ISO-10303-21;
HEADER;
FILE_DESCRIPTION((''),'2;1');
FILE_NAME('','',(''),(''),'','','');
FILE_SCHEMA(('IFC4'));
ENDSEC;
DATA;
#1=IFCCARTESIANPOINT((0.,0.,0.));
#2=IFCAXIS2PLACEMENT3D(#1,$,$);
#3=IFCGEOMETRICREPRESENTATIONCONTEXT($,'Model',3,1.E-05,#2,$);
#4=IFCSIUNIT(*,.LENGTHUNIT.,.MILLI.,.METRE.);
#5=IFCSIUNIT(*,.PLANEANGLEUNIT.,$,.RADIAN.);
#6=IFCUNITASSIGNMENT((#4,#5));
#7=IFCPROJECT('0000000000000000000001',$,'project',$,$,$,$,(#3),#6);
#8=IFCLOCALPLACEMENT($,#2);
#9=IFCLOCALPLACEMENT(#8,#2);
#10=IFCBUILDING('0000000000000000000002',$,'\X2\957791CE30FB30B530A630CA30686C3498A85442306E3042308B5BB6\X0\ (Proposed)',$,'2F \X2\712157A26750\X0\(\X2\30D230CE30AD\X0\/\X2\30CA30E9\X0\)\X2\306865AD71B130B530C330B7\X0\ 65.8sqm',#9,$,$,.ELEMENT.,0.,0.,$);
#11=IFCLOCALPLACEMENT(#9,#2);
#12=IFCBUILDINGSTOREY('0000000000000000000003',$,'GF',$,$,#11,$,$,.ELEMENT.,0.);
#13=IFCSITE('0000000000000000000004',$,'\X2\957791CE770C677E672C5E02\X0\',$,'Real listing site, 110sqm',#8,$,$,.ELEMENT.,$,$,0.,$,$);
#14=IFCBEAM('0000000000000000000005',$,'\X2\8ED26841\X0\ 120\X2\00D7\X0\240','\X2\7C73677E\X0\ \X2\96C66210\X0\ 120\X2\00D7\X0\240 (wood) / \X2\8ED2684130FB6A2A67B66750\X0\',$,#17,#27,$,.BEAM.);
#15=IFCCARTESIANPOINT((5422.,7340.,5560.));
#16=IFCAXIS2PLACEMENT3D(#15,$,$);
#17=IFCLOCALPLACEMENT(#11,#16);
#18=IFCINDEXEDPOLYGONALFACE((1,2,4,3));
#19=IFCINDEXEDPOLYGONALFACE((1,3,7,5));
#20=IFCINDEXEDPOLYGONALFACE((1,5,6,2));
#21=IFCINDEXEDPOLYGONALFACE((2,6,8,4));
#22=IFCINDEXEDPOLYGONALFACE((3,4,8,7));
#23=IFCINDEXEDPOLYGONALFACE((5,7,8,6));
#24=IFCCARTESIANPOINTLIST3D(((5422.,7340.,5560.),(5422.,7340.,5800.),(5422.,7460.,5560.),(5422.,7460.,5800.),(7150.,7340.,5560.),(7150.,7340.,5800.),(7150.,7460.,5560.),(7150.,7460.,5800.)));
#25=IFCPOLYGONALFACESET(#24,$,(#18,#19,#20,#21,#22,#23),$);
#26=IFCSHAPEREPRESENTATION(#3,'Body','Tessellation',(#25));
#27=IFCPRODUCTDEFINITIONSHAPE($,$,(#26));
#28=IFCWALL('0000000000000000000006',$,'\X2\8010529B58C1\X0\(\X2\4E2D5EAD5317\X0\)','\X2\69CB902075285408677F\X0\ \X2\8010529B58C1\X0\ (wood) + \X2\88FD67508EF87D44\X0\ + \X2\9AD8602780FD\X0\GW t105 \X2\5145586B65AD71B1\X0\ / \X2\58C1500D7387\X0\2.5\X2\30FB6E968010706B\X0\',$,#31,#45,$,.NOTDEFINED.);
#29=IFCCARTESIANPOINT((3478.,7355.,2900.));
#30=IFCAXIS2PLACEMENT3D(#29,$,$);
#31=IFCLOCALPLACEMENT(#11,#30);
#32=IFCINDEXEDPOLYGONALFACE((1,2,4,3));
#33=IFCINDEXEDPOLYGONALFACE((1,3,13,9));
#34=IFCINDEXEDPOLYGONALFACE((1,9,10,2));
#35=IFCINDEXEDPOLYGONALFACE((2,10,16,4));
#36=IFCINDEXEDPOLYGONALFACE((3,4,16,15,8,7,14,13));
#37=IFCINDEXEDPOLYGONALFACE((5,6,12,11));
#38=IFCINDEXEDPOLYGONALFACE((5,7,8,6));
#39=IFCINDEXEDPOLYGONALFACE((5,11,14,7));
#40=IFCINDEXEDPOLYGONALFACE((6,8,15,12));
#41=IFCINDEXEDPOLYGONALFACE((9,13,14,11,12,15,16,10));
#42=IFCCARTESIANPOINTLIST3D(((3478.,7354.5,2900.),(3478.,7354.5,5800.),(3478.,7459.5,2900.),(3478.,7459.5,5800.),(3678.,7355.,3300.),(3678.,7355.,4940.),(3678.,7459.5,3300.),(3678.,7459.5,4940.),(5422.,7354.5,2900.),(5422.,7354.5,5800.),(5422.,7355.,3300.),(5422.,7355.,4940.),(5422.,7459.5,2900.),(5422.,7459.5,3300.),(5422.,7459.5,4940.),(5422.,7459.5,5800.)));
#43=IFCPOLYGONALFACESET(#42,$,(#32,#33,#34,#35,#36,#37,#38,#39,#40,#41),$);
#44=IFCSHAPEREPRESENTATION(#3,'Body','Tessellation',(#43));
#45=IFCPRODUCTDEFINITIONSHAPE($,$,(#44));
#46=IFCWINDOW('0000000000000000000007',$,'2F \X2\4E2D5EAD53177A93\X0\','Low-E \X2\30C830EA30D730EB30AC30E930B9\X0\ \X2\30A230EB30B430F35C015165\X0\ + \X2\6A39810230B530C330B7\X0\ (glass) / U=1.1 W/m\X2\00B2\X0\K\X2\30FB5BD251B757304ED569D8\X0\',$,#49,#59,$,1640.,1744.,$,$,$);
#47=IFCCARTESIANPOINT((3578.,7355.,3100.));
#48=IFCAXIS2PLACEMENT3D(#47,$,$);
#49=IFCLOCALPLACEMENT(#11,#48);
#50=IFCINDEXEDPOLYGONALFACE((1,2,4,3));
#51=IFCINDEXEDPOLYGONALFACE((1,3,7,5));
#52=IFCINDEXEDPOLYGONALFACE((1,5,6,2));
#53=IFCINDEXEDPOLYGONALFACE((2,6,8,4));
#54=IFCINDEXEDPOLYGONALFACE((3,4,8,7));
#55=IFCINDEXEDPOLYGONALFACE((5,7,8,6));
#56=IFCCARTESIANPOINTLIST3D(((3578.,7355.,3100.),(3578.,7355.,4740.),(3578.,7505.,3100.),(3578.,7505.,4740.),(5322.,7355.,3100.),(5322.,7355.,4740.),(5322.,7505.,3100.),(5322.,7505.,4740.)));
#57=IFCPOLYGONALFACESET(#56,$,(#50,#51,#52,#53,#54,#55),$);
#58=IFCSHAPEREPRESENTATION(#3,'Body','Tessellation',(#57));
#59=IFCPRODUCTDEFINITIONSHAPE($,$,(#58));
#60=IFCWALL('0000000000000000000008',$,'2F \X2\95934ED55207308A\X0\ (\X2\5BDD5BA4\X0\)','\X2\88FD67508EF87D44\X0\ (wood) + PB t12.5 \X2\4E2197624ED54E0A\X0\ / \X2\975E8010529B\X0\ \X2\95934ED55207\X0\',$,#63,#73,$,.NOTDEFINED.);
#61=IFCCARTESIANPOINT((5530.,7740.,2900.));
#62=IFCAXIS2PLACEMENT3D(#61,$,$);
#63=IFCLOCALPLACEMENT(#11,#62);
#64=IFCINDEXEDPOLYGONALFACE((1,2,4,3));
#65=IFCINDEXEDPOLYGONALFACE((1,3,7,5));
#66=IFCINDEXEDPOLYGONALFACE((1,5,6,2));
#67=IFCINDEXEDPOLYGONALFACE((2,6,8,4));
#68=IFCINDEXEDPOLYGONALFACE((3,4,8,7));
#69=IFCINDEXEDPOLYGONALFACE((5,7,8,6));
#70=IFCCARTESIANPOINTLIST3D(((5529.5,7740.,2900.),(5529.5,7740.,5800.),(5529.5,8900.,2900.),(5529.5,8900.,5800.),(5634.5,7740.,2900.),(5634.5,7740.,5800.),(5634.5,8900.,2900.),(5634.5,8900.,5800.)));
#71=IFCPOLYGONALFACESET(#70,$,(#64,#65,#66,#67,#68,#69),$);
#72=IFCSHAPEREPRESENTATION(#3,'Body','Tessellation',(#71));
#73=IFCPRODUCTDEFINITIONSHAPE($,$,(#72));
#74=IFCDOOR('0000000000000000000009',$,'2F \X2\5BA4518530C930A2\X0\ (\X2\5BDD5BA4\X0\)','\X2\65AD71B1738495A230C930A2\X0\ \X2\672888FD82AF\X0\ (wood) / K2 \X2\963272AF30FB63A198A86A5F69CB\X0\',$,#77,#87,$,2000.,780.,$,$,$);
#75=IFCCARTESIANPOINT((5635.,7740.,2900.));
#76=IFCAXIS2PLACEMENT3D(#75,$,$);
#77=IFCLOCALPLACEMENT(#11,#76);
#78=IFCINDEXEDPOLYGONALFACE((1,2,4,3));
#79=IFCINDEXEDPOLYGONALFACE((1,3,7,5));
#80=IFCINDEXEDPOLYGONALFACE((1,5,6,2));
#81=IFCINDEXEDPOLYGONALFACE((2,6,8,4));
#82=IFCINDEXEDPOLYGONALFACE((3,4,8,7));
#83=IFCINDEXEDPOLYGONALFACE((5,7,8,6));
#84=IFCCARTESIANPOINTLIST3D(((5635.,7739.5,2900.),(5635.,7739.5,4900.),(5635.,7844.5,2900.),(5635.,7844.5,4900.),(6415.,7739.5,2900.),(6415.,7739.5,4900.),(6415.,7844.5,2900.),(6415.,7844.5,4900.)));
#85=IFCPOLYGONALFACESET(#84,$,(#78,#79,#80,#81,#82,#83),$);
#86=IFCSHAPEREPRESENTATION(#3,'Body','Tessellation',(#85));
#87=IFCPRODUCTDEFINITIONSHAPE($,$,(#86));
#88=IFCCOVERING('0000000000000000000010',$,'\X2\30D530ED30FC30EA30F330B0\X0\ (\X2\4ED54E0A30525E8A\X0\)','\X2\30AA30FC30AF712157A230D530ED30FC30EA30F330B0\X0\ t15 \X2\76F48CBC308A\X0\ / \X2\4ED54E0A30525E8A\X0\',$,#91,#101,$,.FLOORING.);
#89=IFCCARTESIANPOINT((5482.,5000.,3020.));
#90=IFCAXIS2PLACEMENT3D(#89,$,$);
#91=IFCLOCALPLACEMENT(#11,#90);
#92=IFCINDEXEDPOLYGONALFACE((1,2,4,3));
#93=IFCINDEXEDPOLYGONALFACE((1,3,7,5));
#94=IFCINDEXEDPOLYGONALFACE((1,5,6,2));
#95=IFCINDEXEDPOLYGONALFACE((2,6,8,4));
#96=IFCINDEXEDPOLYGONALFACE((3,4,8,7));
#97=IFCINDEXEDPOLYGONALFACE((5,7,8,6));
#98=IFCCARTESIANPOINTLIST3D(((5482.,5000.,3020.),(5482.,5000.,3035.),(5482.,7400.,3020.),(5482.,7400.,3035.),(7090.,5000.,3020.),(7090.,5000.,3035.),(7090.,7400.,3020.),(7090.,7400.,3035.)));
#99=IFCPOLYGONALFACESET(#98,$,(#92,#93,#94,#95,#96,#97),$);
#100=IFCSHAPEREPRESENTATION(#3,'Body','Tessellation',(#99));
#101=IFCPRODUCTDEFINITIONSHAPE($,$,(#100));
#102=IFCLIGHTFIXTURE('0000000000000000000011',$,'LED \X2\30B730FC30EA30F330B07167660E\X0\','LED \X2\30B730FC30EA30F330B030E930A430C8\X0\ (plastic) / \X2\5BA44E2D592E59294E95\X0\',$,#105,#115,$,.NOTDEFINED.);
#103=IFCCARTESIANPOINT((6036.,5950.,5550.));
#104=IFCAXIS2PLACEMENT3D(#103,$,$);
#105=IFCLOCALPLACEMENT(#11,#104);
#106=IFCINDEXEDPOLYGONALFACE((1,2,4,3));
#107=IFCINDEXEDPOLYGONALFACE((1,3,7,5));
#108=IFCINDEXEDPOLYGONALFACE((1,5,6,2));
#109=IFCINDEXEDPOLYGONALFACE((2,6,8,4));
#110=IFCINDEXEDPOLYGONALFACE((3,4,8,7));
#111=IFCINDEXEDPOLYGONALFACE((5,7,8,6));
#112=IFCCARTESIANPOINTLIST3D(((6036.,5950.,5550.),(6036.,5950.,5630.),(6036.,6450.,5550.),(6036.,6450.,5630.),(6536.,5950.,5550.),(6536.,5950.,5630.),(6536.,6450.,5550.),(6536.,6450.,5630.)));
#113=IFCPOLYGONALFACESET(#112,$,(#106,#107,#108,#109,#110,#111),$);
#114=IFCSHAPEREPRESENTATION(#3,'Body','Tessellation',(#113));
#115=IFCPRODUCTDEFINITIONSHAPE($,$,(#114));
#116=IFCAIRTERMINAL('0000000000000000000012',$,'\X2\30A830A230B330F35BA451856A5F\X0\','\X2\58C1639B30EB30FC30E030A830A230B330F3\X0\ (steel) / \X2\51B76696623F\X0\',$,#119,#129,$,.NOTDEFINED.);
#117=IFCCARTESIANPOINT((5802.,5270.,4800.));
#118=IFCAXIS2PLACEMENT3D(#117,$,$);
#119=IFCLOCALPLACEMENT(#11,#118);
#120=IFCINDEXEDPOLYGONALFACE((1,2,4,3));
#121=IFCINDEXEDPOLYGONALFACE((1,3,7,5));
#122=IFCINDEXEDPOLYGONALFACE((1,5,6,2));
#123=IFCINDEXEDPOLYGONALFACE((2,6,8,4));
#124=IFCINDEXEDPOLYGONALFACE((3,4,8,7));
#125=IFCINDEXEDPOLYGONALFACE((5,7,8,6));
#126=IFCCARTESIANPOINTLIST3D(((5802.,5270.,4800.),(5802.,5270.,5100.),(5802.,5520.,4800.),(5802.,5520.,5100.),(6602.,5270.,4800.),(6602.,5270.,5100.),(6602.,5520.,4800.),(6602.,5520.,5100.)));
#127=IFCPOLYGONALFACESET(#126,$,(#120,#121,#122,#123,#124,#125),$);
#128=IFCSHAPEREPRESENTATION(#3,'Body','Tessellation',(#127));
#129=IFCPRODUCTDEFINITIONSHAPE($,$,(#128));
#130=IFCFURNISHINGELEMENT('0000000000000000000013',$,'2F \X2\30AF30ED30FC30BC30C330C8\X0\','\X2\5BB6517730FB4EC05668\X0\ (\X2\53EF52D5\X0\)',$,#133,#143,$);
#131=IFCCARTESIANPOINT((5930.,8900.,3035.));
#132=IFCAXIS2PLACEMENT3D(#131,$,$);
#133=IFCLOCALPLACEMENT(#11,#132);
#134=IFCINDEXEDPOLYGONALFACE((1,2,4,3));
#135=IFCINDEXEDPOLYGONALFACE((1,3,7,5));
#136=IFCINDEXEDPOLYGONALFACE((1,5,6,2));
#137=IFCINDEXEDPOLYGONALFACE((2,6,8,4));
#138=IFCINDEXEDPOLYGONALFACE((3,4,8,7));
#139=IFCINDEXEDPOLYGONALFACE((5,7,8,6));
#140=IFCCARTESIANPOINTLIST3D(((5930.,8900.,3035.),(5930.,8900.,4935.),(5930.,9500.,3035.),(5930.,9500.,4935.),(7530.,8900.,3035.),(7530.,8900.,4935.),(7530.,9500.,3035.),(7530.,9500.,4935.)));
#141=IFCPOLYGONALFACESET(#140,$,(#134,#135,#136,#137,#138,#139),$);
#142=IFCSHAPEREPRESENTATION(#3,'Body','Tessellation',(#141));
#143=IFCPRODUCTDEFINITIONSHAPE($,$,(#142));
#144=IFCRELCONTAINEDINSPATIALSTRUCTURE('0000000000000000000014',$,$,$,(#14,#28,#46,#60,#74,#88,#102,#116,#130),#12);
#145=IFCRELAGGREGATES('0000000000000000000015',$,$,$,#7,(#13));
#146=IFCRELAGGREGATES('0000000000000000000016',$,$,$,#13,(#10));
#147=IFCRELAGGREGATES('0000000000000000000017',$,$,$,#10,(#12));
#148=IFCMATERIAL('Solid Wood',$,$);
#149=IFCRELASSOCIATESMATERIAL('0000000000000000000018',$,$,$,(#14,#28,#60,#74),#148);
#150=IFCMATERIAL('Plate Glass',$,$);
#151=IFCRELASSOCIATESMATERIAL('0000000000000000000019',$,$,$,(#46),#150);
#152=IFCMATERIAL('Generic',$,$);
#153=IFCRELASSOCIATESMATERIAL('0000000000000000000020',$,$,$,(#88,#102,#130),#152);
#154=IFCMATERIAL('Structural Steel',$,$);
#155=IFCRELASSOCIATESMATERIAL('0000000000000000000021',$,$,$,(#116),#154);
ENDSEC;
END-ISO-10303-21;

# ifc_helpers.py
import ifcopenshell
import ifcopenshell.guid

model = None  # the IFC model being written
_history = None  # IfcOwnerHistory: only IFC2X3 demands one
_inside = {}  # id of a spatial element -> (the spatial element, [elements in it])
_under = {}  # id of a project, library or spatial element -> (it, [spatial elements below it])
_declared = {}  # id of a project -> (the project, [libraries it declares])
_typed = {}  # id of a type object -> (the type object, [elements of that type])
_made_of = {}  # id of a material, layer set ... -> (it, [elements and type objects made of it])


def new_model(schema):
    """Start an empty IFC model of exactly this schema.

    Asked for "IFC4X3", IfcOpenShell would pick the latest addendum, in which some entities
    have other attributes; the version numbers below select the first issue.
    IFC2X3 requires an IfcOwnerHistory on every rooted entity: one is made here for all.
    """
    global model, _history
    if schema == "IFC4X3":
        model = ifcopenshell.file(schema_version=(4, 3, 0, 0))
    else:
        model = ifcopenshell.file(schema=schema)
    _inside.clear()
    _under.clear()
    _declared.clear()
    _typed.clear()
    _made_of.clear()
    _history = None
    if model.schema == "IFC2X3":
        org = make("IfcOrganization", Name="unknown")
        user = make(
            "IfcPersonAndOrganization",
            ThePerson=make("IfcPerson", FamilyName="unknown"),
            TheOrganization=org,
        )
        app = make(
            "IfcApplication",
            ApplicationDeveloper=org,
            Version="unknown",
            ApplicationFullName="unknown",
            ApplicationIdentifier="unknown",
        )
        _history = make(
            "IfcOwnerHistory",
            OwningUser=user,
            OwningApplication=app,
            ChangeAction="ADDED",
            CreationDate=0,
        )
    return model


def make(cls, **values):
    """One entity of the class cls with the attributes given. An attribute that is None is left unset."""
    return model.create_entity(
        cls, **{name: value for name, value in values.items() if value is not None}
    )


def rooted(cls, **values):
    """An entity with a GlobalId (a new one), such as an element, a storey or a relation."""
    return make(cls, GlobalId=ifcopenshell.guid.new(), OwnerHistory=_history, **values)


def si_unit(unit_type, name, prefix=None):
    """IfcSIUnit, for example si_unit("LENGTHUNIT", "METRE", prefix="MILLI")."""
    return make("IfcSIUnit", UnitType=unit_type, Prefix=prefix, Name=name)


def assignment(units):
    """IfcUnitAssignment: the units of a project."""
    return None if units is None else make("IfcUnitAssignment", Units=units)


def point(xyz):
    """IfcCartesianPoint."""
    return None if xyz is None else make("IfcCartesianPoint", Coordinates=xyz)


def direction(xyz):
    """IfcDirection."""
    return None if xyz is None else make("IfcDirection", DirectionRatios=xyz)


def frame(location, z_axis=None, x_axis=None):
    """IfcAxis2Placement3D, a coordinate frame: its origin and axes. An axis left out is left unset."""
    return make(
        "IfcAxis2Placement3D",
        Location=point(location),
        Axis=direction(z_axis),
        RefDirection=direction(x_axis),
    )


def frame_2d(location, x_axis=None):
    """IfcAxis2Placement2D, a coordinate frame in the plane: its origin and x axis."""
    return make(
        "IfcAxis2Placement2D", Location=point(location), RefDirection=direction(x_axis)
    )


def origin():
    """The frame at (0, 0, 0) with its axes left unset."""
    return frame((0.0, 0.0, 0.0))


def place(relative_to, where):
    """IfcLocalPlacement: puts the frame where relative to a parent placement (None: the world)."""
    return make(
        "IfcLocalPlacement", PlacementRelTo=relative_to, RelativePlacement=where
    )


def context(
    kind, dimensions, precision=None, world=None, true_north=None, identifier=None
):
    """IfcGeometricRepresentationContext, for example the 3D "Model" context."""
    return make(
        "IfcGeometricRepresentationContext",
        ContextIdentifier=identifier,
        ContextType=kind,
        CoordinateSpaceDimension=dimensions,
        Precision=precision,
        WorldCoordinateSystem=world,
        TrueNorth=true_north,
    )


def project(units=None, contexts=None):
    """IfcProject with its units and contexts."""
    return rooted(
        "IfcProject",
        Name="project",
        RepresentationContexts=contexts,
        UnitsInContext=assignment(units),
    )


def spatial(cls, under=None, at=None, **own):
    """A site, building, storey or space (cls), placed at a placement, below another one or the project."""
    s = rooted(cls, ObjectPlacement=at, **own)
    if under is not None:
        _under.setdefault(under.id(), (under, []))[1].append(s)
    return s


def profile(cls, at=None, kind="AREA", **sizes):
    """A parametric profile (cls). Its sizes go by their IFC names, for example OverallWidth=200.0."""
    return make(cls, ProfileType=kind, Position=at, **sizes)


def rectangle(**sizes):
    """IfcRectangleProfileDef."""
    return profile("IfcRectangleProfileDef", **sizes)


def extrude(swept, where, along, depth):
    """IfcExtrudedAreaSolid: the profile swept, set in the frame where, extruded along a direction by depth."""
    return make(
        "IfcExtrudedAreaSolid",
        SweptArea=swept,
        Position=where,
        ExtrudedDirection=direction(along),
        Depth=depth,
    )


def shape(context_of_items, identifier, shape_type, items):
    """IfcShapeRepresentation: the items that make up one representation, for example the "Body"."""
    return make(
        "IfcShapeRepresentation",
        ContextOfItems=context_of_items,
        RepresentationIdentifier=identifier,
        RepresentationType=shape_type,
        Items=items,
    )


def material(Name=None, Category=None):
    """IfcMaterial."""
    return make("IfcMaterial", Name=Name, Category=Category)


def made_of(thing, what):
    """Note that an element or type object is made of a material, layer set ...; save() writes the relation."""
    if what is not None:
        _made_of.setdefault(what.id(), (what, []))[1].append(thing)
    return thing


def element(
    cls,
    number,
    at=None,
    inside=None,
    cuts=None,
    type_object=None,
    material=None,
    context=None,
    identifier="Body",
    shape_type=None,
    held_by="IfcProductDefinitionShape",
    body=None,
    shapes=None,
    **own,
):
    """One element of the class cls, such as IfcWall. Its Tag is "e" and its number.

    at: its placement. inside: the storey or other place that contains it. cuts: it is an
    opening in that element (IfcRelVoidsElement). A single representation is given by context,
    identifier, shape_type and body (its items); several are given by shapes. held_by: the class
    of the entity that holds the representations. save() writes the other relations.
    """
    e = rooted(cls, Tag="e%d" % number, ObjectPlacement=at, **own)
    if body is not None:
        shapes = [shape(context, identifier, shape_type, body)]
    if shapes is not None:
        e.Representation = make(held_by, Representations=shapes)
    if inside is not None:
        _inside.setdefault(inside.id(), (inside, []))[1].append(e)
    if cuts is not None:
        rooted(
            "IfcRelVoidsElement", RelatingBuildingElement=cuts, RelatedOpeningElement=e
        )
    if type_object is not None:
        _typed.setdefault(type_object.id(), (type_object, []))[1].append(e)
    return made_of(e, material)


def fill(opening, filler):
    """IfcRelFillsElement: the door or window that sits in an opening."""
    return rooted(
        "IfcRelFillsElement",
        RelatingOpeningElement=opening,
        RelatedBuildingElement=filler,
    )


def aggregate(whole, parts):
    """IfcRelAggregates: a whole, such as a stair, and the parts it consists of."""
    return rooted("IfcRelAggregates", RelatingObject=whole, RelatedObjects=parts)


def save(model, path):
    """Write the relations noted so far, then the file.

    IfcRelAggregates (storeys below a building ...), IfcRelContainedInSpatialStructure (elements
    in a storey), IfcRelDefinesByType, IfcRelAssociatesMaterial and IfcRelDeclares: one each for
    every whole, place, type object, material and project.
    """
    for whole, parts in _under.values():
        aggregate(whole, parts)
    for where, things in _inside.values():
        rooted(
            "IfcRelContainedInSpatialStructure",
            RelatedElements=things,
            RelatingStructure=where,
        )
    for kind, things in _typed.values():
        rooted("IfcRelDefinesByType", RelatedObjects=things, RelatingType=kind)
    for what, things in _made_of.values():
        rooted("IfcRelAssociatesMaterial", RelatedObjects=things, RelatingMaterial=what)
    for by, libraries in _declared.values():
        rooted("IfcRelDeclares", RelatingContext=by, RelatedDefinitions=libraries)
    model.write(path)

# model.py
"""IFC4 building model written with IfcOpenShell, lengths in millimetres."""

from ifc_helpers import new_model, si_unit, frame, frame_2d, origin, place, context, project, spatial, rectangle, extrude, material, element, fill, save


model = new_model("IFC4")

# Units and contexts
model_context = context("Model", 3, precision=1e-05, world=origin())
ifc_project = project(units=[si_unit("LENGTHUNIT", "METRE", prefix="MILLI"), si_unit("PLANEANGLEUNIT", "RADIAN")], contexts=[model_context])

# Site, building, storey
site_placement = place(None, origin())
site = spatial("IfcSite", under=ifc_project, at=site_placement, Name="長野県松本市", ObjectType="Real listing site, 110sqm", CompositionType="ELEMENT", RefElevation=0.0)
building_placement = place(site_placement, origin())
building = spatial("IfcBuilding", under=site, at=building_placement, Name="長野・サウナと水風呂のある家 (Proposed)", ObjectType="2F 無垢材(ヒノキ/ナラ)と断熱サッシ 65.8sqm", CompositionType="ELEMENT", ElevationOfRefHeight=0.0, ElevationOfTerrain=0.0)
storey_placement = place(building_placement, origin())
storey = spatial("IfcBuildingStorey", under=building, at=storey_placement, Name="GF", CompositionType="ELEMENT", Elevation=0.0)

# Shared definitions
ifc_material_1 = material(Name="Solid Wood")

# Beam
beam_1_placement = place(storey_placement, frame((5422.0, 7340.0, 5560.0)))
element("IfcBeam", 1, at=beam_1_placement, inside=storey, material=ifc_material_1, Name="軒桁 120×240", Description="米松 集成 120×240 (wood) / 軒桁・横架材", PredefinedType="BEAM", context=model_context, shape_type="SweptSolid", body=[
    extrude(rectangle(XDim=1728.0, YDim=120.0, at=frame_2d((864.0, 60.0))), frame((5422.0, 7340.0, 5560.0)), (0.0, 0.0, 1.0), 240.0),
])

# Wall, opening, window
wall_1_placement = place(storey_placement, frame((3478.0, 7355.0, 2900.0)))
wall_1 = element("IfcWall", 2, at=wall_1_placement, inside=storey, material=ifc_material_1, Name="耐力壁(中庭北)", Description="構造用合板 耐力壁 (wood) + 製材軸組 + 高性能GW t105 充填断熱 / 壁倍率2.5・準耐火", PredefinedType="NOTDEFINED", context=model_context, shape_type="SweptSolid", body=[
    extrude(rectangle(XDim=1944.0, YDim=105.0, at=frame_2d((972.0, 52.0))), frame((3478.0, 7355.0, 2900.0)), (0.0, 0.0, 1.0), 2900.0),
])
opening_placement = place(storey_placement, frame((3578.0, 7355.0, 3100.0)))
opening = element("IfcOpeningElement", 3, at=opening_placement, cuts=wall_1, PredefinedType="NOTDEFINED", context=model_context, shape_type="SweptSolid", body=[
    extrude(rectangle(XDim=1744.0, YDim=150.0, at=frame_2d((872.0, 75.0))), frame((3578.0, 7355.0, 3100.0)), (0.0, 0.0, 1.0), 1640.0),
])
ifc_material_2 = material(Name="Plate Glass")
window_placement = place(storey_placement, frame((3578.0, 7355.0, 3100.0)))
window = element("IfcWindow", 4, at=window_placement, inside=storey, material=ifc_material_2, Name="2F 中庭北窓", Description="Low-E トリプルガラス アルゴン封入 + 樹脂サッシ (glass) / U=1.1 W/m²K・寒冷地仕様", OverallHeight=1640.0, OverallWidth=1744.0, context=model_context, shape_type="SweptSolid", body=[
    extrude(rectangle(XDim=1744.0, YDim=150.0, at=frame_2d((872.0, 75.0))), frame((3578.0, 7355.0, 3100.0)), (0.0, 0.0, 1.0), 1640.0),
])
fill(opening, window)

# Wall
wall_2_placement = place(storey_placement, frame((5530.0, 7740.0, 2900.0)))
element("IfcWall", 5, at=wall_2_placement, inside=storey, material=ifc_material_1, Name="2F 間仕切り (寝室)", Description="製材軸組 (wood) + PB t12.5 両面仕上 / 非耐力 間仕切", PredefinedType="NOTDEFINED", context=model_context, shape_type="SweptSolid", body=[
    extrude(rectangle(XDim=105.0, YDim=1160.0, at=frame_2d((52.0, 580.0))), frame((5530.0, 7740.0, 2900.0)), (0.0, 0.0, 1.0), 2900.0),
])

# Door
door_placement = place(storey_placement, frame((5635.0, 7740.0, 2900.0)))
element("IfcDoor", 6, at=door_placement, inside=storey, material=ifc_material_1, Name="2F 室内ドア (寝室)", Description="断熱玄関ドア 木製芯 (wood) / K2 防犯・採風機構", OverallHeight=2000.0, OverallWidth=780.0, context=model_context, shape_type="SweptSolid", body=[
    extrude(rectangle(XDim=780.0, YDim=105.0, at=frame_2d((390.0, 52.0))), frame((5635.0, 7740.0, 2900.0)), (0.0, 0.0, 1.0), 2000.0),
])

# Covering
ifc_material_3 = material(Name="Generic")
covering_placement = place(storey_placement, frame((5482.0, 5000.0, 3020.0)))
element("IfcCovering", 7, at=covering_placement, inside=storey, material=ifc_material_3, Name="フローリング (仕上げ床)", Description="オーク無垢フローリング t15 直貼り / 仕上げ床", PredefinedType="FLOORING", context=model_context, shape_type="SweptSolid", body=[
    extrude(rectangle(XDim=1608.0, YDim=2400.0, at=frame_2d((804.0, 1200.0))), frame((5482.0, 5000.0, 3020.0)), (0.0, 0.0, 1.0), 15.0),
])

# Light fixture
light_fixture_placement = place(storey_placement, frame((6036.0, 5950.0, 5550.0)))
element("IfcLightFixture", 8, at=light_fixture_placement, inside=storey, material=ifc_material_3, Name="LED シーリング照明", Description="LED シーリングライト (plastic) / 室中央天井", PredefinedType="NOTDEFINED", context=model_context, shape_type="SweptSolid", body=[
    extrude(rectangle(XDim=500.0, YDim=500.0, at=frame_2d((250.0, 250.0))), frame((6036.0, 5950.0, 5550.0)), (0.0, 0.0, 1.0), 80.0),
])

# Air terminal
ifc_material_4 = material(Name="Structural Steel")
air_terminal_placement = place(storey_placement, frame((5802.0, 5270.0, 4800.0)))
element("IfcAirTerminal", 9, at=air_terminal_placement, inside=storey, material=ifc_material_4, Name="エアコン室内機", Description="壁掛ルームエアコン (steel) / 冷暖房", PredefinedType="NOTDEFINED", context=model_context, shape_type="SweptSolid", body=[
    extrude(rectangle(XDim=800.0, YDim=250.0, at=frame_2d((400.0, 125.0))), frame((5802.0, 5270.0, 4800.0)), (0.0, 0.0, 1.0), 300.0),
])

# Furnishing element
furnishing_placement = place(storey_placement, frame((5930.0, 8900.0, 3035.0)))
element("IfcFurnishingElement", 10, at=furnishing_placement, inside=storey, material=ifc_material_3, Name="2F クローゼット", Description="家具・什器 (可動)", context=model_context, shape_type="SweptSolid", body=[
    extrude(rectangle(XDim=1600.0, YDim=600.0, at=frame_2d((800.0, 300.0))), frame((5930.0, 8900.0, 3035.0)), (0.0, 0.0, 1.0), 1900.0),
])

save(model, "model.ifc")
